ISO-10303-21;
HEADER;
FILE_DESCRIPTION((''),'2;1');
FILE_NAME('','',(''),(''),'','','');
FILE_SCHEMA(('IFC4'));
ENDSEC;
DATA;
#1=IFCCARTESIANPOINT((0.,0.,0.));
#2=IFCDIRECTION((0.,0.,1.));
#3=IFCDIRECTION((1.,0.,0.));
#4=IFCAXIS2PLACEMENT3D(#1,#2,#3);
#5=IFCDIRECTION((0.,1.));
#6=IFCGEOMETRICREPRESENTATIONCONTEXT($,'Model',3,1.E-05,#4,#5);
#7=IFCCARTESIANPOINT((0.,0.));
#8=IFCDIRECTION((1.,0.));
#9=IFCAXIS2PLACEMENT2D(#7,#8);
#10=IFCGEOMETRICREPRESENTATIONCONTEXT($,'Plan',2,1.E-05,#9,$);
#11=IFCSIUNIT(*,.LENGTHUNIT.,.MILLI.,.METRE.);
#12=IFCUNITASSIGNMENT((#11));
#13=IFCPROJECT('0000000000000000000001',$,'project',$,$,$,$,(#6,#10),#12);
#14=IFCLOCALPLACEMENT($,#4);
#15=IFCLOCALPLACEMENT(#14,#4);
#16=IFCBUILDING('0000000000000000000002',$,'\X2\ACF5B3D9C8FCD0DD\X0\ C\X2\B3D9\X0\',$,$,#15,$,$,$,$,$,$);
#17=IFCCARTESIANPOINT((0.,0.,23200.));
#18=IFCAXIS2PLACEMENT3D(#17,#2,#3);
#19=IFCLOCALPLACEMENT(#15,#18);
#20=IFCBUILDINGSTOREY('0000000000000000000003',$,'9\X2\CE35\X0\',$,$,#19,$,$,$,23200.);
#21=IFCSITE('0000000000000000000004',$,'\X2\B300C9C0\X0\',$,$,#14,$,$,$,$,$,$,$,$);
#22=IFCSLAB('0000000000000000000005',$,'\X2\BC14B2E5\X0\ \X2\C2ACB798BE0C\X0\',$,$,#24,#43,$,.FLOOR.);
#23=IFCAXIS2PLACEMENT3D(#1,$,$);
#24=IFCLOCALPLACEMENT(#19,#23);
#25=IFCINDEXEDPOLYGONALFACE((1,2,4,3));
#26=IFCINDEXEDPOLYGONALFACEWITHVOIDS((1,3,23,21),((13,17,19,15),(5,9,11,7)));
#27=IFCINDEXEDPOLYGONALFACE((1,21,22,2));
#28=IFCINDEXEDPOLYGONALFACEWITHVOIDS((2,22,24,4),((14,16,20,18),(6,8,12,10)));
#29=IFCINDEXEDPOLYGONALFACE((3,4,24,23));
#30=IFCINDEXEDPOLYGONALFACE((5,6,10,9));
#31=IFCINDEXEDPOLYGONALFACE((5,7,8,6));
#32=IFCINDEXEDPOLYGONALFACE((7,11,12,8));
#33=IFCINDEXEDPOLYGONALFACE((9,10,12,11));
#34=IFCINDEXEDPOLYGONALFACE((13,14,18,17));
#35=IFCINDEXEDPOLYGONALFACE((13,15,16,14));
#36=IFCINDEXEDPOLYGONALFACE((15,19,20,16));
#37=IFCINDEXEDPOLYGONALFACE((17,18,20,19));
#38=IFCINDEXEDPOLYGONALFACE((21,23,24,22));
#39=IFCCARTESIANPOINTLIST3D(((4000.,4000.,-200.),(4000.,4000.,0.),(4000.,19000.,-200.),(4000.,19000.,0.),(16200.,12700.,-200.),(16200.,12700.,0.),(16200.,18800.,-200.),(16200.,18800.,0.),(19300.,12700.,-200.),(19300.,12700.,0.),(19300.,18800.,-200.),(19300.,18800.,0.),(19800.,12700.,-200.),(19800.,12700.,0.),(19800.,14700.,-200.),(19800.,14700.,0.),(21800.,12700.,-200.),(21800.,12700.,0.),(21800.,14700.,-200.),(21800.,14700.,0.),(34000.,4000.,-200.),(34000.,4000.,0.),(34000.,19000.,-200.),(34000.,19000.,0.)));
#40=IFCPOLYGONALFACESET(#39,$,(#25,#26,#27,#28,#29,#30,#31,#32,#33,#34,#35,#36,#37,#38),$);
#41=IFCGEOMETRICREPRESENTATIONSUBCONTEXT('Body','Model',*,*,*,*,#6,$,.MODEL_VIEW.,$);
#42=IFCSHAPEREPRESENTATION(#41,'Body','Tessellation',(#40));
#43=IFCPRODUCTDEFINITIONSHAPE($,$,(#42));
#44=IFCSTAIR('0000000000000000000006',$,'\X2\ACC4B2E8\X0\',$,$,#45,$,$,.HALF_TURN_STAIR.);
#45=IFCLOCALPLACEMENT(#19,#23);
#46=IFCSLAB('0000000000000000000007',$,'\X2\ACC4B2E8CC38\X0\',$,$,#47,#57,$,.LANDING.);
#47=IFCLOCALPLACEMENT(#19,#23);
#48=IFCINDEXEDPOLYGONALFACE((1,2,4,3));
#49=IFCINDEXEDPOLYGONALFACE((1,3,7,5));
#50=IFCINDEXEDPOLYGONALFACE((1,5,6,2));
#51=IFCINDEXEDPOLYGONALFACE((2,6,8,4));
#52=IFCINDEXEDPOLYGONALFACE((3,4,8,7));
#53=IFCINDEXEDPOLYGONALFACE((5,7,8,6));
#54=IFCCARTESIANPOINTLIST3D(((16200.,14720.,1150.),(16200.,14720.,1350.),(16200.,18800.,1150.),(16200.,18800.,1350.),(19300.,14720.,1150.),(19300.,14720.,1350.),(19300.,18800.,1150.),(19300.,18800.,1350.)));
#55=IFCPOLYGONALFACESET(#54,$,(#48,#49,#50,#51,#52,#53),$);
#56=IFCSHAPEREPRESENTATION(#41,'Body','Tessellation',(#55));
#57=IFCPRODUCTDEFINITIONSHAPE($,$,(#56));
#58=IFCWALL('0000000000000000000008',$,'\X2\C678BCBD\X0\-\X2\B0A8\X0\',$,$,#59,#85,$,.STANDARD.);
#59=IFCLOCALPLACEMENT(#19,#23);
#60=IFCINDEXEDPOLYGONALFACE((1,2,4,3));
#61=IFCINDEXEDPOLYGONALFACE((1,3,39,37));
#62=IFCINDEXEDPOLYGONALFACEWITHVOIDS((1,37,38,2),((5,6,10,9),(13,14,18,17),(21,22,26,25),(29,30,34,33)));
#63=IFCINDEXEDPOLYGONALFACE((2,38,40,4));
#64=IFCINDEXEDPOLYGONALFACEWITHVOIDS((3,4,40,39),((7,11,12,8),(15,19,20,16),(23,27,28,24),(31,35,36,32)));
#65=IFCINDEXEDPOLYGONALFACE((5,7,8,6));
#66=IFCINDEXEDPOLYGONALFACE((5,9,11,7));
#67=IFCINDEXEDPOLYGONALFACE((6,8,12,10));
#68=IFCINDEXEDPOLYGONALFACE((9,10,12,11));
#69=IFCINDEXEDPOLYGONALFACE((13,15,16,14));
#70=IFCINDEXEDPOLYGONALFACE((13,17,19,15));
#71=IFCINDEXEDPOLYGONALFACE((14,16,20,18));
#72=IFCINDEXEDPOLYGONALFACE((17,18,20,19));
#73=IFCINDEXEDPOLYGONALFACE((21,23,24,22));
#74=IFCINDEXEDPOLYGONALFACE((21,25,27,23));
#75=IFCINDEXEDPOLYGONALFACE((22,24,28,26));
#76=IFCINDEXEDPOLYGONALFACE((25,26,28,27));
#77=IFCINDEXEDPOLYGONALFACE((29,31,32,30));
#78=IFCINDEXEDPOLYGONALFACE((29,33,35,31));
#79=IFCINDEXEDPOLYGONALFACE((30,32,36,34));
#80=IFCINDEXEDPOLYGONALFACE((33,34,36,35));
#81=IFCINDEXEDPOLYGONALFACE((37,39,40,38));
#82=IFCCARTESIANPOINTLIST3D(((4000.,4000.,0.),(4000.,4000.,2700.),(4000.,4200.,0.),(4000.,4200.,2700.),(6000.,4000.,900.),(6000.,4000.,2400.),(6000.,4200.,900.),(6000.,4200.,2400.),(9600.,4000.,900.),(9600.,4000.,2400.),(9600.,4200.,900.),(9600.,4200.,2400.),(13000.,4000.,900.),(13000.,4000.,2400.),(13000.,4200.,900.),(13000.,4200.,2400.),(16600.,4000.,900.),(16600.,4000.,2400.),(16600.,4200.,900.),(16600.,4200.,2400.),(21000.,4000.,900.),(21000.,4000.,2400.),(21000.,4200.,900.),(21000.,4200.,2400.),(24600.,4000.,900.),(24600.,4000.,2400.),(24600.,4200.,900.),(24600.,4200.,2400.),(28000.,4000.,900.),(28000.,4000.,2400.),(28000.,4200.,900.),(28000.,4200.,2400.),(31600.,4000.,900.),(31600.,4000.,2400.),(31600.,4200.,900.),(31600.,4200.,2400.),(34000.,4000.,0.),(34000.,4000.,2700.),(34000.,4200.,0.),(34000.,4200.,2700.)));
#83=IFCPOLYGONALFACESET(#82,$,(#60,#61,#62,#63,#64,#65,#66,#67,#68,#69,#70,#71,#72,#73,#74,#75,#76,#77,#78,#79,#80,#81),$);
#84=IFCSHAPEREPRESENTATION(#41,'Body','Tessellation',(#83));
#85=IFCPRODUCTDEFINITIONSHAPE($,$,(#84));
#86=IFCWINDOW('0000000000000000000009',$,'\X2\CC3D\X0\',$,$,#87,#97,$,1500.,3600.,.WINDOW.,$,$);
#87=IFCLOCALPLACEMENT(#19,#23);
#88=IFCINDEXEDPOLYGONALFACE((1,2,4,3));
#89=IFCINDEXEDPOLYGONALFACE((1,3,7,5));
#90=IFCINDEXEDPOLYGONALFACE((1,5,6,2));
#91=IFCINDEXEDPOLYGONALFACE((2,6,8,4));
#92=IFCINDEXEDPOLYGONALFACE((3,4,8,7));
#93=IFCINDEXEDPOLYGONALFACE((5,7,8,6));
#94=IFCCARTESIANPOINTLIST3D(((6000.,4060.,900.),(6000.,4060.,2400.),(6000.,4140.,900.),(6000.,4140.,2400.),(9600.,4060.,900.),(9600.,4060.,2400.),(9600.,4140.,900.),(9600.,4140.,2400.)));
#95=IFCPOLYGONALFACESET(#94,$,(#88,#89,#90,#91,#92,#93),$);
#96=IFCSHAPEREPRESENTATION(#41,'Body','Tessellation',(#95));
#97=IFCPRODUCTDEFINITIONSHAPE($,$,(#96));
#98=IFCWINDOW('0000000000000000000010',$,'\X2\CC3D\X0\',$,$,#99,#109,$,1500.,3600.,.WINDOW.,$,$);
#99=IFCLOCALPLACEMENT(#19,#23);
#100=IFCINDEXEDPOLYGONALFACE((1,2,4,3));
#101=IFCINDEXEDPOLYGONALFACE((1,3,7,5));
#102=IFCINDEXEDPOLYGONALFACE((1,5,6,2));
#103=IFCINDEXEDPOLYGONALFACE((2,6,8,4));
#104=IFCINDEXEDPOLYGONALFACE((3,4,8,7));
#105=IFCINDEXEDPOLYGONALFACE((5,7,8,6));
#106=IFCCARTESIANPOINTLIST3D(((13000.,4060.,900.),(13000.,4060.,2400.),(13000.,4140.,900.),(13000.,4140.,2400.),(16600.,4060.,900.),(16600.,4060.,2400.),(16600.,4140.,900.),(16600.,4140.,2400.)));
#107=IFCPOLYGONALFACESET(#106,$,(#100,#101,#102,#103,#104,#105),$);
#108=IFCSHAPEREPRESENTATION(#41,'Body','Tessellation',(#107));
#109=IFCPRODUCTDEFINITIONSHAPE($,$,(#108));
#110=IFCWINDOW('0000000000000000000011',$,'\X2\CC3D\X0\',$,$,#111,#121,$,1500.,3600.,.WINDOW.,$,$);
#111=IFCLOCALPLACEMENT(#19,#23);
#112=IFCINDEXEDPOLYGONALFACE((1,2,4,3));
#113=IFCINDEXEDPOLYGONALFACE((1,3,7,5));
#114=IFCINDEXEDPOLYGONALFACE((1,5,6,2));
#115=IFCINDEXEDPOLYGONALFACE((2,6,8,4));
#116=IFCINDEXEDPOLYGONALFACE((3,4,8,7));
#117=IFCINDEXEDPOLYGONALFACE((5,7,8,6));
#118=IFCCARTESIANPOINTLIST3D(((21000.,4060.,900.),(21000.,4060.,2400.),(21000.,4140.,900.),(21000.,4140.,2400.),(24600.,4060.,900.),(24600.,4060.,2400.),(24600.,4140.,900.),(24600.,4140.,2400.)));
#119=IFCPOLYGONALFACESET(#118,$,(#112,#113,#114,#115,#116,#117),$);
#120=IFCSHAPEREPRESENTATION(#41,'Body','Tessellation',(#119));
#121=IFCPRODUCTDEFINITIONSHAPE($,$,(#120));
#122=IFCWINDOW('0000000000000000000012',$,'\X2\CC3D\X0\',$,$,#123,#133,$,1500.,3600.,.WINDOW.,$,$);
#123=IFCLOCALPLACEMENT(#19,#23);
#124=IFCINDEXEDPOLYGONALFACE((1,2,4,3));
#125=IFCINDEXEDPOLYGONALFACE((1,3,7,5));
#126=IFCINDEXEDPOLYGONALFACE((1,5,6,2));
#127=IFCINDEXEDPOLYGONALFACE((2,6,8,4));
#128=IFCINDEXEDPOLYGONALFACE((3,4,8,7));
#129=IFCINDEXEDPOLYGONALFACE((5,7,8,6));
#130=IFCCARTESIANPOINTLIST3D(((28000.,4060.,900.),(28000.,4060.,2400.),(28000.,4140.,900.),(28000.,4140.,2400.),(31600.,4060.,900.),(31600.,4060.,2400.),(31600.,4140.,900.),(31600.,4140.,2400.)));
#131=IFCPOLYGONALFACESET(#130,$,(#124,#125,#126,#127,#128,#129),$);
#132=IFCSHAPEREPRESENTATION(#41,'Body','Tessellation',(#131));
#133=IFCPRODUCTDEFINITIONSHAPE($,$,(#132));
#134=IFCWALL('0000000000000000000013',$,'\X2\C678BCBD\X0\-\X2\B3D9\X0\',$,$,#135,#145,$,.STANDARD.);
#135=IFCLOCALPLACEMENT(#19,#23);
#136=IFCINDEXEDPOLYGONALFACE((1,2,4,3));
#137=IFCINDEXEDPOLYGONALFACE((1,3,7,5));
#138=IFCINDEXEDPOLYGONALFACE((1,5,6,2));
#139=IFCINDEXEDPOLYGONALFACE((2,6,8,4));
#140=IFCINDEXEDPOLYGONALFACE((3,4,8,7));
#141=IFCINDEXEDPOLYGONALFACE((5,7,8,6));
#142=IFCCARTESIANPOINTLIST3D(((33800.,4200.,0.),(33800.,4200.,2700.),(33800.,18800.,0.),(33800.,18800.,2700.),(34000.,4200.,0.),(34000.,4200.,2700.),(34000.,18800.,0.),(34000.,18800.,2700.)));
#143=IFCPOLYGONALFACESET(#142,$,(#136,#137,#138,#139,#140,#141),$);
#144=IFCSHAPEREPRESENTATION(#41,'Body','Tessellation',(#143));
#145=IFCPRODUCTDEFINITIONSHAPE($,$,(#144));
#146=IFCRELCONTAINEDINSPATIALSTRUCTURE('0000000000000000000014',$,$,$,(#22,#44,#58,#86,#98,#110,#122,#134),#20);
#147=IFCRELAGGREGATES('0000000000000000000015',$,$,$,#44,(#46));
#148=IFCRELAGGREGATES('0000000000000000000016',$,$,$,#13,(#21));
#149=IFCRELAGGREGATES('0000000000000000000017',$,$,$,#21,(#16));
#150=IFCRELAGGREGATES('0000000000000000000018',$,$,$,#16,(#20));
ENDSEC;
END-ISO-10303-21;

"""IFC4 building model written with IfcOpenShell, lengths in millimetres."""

from ifc_helpers import new_model, si_unit, direction, frame, origin_with_axes, origin_2d_with_axis, place, context, subcontext, project, spatial, polyline, outline, extrude, element, fill, aggregate, save


model = new_model("IFC4")

# Units and contexts
model_context = context("Model", 3, precision=1e-05, world=origin_with_axes(), true_north=direction((0.0, 1.0)))
plan_context = context("Plan", 2, precision=1e-05, world=origin_2d_with_axis())
body_context = subcontext(model_context, "Body", "Model", "MODEL_VIEW")
ifc_project = project(units=[si_unit("LENGTHUNIT", "METRE", prefix="MILLI")], contexts=[model_context, plan_context])

# Site, building, storey
site_placement = place(None, origin_with_axes())
site = spatial("IfcSite", under=ifc_project, at=site_placement, Name="대지")
building_placement = place(site_placement, origin_with_axes())
building = spatial("IfcBuilding", under=site, at=building_placement, Name="공동주택 C동")
storey_placement = place(building_placement, frame((0.0, 0.0, 23200.0), z_axis=(0.0, 0.0, 1.0), x_axis=(1.0, 0.0, 0.0)))
storey = spatial("IfcBuildingStorey", under=building, at=storey_placement, Name="9층", Elevation=23200.0)

# Slab
slab_1_placement = place(storey_placement, origin_with_axes())
element("IfcSlab", 1, at=slab_1_placement, inside=storey, Name="바닥 슬래브", PredefinedType="FLOOR", context=body_context, shape_type="SweptSolid", body=[
    extrude(outline(polyline([(4000.0, 4000.0), (34000.0, 4000.0), (34000.0, 19000.0), (4000.0, 19000.0), (4000.0, 4000.0)]), holes=[polyline([(16200.0, 12700.0), (19300.0, 12700.0), (19300.0, 18800.0), (16200.0, 18800.0), (16200.0, 12700.0)]), polyline([(19800.0, 12700.0), (21800.0, 12700.0), (21800.0, 14700.0), (19800.0, 14700.0), (19800.0, 12700.0)])]), frame((0.0, 0.0, -200.0), z_axis=(0.0, 0.0, 1.0), x_axis=(1.0, 0.0, 0.0)), (0.0, 0.0, 1.0), 200.0),
])

# Stair, slab
stair_placement = place(storey_placement, origin_with_axes())
stair = element("IfcStair", 2, at=stair_placement, inside=storey, Name="계단", PredefinedType="HALF_TURN_STAIR")
slab_2_placement = place(stair_placement, origin_with_axes())
slab_2 = element("IfcSlab", 3, at=slab_2_placement, Name="계단참", PredefinedType="LANDING", context=body_context, shape_type="SweptSolid", body=[
    extrude(outline(polyline([(16200.0, 14720.0), (19300.0, 14720.0), (19300.0, 18800.0), (16200.0, 18800.0), (16200.0, 14720.0)])), frame((0.0, 0.0, 1150.0), z_axis=(0.0, 0.0, 1.0), x_axis=(1.0, 0.0, 0.0)), (0.0, 0.0, 1.0), 200.0),
])

# Wall, openings, windows
wall_1_placement = place(storey_placement, origin_with_axes())
wall_1 = element("IfcWall", 4, at=wall_1_placement, inside=storey, Name="외벽-남", PredefinedType="STANDARD", context=body_context, shape_type="SweptSolid", body=[
    extrude(outline(polyline([(4000.0, 4200.0), (34000.0, 4200.0), (34000.0, 4000.0), (4000.0, 4000.0), (4000.0, 4200.0)])), origin_with_axes(), (0.0, 0.0, 1.0), 2700.0),
])
opening_1_placement = place(storey_placement, origin_with_axes())
opening_1 = element("IfcOpeningElement", 5, at=opening_1_placement, cuts=wall_1, PredefinedType="OPENING", context=body_context, shape_type="SweptSolid", body=[
    extrude(outline(polyline([(6000.0, 3950.0), (9600.0, 3950.0), (9600.0, 4250.0), (6000.0, 4250.0), (6000.0, 3950.0)])), frame((0.0, 0.0, 900.0), z_axis=(0.0, 0.0, 1.0), x_axis=(1.0, 0.0, 0.0)), (0.0, 0.0, 1.0), 1500.0),
])
opening_2_placement = place(storey_placement, origin_with_axes())
opening_2 = element("IfcOpeningElement", 6, at=opening_2_placement, cuts=wall_1, PredefinedType="OPENING", context=body_context, shape_type="SweptSolid", body=[
    extrude(outline(polyline([(13000.0, 3950.0), (16600.0, 3950.0), (16600.0, 4250.0), (13000.0, 4250.0), (13000.0, 3950.0)])), frame((0.0, 0.0, 900.0), z_axis=(0.0, 0.0, 1.0), x_axis=(1.0, 0.0, 0.0)), (0.0, 0.0, 1.0), 1500.0),
])
opening_3_placement = place(storey_placement, origin_with_axes())
opening_3 = element("IfcOpeningElement", 7, at=opening_3_placement, cuts=wall_1, PredefinedType="OPENING", context=body_context, shape_type="SweptSolid", body=[
    extrude(outline(polyline([(21000.0, 3950.0), (24600.0, 3950.0), (24600.0, 4250.0), (21000.0, 4250.0), (21000.0, 3950.0)])), frame((0.0, 0.0, 900.0), z_axis=(0.0, 0.0, 1.0), x_axis=(1.0, 0.0, 0.0)), (0.0, 0.0, 1.0), 1500.0),
])
opening_4_placement = place(storey_placement, origin_with_axes())
opening_4 = element("IfcOpeningElement", 8, at=opening_4_placement, cuts=wall_1, PredefinedType="OPENING", context=body_context, shape_type="SweptSolid", body=[
    extrude(outline(polyline([(28000.0, 3950.0), (31600.0, 3950.0), (31600.0, 4250.0), (28000.0, 4250.0), (28000.0, 3950.0)])), frame((0.0, 0.0, 900.0), z_axis=(0.0, 0.0, 1.0), x_axis=(1.0, 0.0, 0.0)), (0.0, 0.0, 1.0), 1500.0),
])
window_1_placement = place(storey_placement, origin_with_axes())
window_1 = element("IfcWindow", 9, at=window_1_placement, inside=storey, Name="창", OverallHeight=1500.0, OverallWidth=3600.0, PredefinedType="WINDOW", context=body_context, shape_type="SweptSolid", body=[
    extrude(outline(polyline([(6000.0, 4060.0), (9600.0, 4060.0), (9600.0, 4140.0), (6000.0, 4140.0), (6000.0, 4060.0)])), frame((0.0, 0.0, 900.0), z_axis=(0.0, 0.0, 1.0), x_axis=(1.0, 0.0, 0.0)), (0.0, 0.0, 1.0), 1500.0),
])
fill(opening_1, window_1)
window_2_placement = place(storey_placement, origin_with_axes())
window_2 = element("IfcWindow", 10, at=window_2_placement, inside=storey, Name="창", OverallHeight=1500.0, OverallWidth=3600.0, PredefinedType="WINDOW", context=body_context, shape_type="SweptSolid", body=[
    extrude(outline(polyline([(13000.0, 4060.0), (16600.0, 4060.0), (16600.0, 4140.0), (13000.0, 4140.0), (13000.0, 4060.0)])), frame((0.0, 0.0, 900.0), z_axis=(0.0, 0.0, 1.0), x_axis=(1.0, 0.0, 0.0)), (0.0, 0.0, 1.0), 1500.0),
])
fill(opening_2, window_2)
window_3_placement = place(storey_placement, origin_with_axes())
window_3 = element("IfcWindow", 11, at=window_3_placement, inside=storey, Name="창", OverallHeight=1500.0, OverallWidth=3600.0, PredefinedType="WINDOW", context=body_context, shape_type="SweptSolid", body=[
    extrude(outline(polyline([(21000.0, 4060.0), (24600.0, 4060.0), (24600.0, 4140.0), (21000.0, 4140.0), (21000.0, 4060.0)])), frame((0.0, 0.0, 900.0), z_axis=(0.0, 0.0, 1.0), x_axis=(1.0, 0.0, 0.0)), (0.0, 0.0, 1.0), 1500.0),
])
fill(opening_3, window_3)
window_4_placement = place(storey_placement, origin_with_axes())
window_4 = element("IfcWindow", 12, at=window_4_placement, inside=storey, Name="창", OverallHeight=1500.0, OverallWidth=3600.0, PredefinedType="WINDOW", context=body_context, shape_type="SweptSolid", body=[
    extrude(outline(polyline([(28000.0, 4060.0), (31600.0, 4060.0), (31600.0, 4140.0), (28000.0, 4140.0), (28000.0, 4060.0)])), frame((0.0, 0.0, 900.0), z_axis=(0.0, 0.0, 1.0), x_axis=(1.0, 0.0, 0.0)), (0.0, 0.0, 1.0), 1500.0),
])
fill(opening_4, window_4)

# Wall
wall_2_placement = place(storey_placement, origin_with_axes())
element("IfcWall", 13, at=wall_2_placement, inside=storey, Name="외벽-동", PredefinedType="STANDARD", context=body_context, shape_type="SweptSolid", body=[
    extrude(outline(polyline([(33800.0, 4200.0), (33800.0, 18800.0), (34000.0, 18800.0), (34000.0, 4200.0), (33800.0, 4200.0)])), origin_with_axes(), (0.0, 0.0, 1.0), 2700.0),
])

aggregate(stair, [slab_2])

save(model, "model.ifc")
